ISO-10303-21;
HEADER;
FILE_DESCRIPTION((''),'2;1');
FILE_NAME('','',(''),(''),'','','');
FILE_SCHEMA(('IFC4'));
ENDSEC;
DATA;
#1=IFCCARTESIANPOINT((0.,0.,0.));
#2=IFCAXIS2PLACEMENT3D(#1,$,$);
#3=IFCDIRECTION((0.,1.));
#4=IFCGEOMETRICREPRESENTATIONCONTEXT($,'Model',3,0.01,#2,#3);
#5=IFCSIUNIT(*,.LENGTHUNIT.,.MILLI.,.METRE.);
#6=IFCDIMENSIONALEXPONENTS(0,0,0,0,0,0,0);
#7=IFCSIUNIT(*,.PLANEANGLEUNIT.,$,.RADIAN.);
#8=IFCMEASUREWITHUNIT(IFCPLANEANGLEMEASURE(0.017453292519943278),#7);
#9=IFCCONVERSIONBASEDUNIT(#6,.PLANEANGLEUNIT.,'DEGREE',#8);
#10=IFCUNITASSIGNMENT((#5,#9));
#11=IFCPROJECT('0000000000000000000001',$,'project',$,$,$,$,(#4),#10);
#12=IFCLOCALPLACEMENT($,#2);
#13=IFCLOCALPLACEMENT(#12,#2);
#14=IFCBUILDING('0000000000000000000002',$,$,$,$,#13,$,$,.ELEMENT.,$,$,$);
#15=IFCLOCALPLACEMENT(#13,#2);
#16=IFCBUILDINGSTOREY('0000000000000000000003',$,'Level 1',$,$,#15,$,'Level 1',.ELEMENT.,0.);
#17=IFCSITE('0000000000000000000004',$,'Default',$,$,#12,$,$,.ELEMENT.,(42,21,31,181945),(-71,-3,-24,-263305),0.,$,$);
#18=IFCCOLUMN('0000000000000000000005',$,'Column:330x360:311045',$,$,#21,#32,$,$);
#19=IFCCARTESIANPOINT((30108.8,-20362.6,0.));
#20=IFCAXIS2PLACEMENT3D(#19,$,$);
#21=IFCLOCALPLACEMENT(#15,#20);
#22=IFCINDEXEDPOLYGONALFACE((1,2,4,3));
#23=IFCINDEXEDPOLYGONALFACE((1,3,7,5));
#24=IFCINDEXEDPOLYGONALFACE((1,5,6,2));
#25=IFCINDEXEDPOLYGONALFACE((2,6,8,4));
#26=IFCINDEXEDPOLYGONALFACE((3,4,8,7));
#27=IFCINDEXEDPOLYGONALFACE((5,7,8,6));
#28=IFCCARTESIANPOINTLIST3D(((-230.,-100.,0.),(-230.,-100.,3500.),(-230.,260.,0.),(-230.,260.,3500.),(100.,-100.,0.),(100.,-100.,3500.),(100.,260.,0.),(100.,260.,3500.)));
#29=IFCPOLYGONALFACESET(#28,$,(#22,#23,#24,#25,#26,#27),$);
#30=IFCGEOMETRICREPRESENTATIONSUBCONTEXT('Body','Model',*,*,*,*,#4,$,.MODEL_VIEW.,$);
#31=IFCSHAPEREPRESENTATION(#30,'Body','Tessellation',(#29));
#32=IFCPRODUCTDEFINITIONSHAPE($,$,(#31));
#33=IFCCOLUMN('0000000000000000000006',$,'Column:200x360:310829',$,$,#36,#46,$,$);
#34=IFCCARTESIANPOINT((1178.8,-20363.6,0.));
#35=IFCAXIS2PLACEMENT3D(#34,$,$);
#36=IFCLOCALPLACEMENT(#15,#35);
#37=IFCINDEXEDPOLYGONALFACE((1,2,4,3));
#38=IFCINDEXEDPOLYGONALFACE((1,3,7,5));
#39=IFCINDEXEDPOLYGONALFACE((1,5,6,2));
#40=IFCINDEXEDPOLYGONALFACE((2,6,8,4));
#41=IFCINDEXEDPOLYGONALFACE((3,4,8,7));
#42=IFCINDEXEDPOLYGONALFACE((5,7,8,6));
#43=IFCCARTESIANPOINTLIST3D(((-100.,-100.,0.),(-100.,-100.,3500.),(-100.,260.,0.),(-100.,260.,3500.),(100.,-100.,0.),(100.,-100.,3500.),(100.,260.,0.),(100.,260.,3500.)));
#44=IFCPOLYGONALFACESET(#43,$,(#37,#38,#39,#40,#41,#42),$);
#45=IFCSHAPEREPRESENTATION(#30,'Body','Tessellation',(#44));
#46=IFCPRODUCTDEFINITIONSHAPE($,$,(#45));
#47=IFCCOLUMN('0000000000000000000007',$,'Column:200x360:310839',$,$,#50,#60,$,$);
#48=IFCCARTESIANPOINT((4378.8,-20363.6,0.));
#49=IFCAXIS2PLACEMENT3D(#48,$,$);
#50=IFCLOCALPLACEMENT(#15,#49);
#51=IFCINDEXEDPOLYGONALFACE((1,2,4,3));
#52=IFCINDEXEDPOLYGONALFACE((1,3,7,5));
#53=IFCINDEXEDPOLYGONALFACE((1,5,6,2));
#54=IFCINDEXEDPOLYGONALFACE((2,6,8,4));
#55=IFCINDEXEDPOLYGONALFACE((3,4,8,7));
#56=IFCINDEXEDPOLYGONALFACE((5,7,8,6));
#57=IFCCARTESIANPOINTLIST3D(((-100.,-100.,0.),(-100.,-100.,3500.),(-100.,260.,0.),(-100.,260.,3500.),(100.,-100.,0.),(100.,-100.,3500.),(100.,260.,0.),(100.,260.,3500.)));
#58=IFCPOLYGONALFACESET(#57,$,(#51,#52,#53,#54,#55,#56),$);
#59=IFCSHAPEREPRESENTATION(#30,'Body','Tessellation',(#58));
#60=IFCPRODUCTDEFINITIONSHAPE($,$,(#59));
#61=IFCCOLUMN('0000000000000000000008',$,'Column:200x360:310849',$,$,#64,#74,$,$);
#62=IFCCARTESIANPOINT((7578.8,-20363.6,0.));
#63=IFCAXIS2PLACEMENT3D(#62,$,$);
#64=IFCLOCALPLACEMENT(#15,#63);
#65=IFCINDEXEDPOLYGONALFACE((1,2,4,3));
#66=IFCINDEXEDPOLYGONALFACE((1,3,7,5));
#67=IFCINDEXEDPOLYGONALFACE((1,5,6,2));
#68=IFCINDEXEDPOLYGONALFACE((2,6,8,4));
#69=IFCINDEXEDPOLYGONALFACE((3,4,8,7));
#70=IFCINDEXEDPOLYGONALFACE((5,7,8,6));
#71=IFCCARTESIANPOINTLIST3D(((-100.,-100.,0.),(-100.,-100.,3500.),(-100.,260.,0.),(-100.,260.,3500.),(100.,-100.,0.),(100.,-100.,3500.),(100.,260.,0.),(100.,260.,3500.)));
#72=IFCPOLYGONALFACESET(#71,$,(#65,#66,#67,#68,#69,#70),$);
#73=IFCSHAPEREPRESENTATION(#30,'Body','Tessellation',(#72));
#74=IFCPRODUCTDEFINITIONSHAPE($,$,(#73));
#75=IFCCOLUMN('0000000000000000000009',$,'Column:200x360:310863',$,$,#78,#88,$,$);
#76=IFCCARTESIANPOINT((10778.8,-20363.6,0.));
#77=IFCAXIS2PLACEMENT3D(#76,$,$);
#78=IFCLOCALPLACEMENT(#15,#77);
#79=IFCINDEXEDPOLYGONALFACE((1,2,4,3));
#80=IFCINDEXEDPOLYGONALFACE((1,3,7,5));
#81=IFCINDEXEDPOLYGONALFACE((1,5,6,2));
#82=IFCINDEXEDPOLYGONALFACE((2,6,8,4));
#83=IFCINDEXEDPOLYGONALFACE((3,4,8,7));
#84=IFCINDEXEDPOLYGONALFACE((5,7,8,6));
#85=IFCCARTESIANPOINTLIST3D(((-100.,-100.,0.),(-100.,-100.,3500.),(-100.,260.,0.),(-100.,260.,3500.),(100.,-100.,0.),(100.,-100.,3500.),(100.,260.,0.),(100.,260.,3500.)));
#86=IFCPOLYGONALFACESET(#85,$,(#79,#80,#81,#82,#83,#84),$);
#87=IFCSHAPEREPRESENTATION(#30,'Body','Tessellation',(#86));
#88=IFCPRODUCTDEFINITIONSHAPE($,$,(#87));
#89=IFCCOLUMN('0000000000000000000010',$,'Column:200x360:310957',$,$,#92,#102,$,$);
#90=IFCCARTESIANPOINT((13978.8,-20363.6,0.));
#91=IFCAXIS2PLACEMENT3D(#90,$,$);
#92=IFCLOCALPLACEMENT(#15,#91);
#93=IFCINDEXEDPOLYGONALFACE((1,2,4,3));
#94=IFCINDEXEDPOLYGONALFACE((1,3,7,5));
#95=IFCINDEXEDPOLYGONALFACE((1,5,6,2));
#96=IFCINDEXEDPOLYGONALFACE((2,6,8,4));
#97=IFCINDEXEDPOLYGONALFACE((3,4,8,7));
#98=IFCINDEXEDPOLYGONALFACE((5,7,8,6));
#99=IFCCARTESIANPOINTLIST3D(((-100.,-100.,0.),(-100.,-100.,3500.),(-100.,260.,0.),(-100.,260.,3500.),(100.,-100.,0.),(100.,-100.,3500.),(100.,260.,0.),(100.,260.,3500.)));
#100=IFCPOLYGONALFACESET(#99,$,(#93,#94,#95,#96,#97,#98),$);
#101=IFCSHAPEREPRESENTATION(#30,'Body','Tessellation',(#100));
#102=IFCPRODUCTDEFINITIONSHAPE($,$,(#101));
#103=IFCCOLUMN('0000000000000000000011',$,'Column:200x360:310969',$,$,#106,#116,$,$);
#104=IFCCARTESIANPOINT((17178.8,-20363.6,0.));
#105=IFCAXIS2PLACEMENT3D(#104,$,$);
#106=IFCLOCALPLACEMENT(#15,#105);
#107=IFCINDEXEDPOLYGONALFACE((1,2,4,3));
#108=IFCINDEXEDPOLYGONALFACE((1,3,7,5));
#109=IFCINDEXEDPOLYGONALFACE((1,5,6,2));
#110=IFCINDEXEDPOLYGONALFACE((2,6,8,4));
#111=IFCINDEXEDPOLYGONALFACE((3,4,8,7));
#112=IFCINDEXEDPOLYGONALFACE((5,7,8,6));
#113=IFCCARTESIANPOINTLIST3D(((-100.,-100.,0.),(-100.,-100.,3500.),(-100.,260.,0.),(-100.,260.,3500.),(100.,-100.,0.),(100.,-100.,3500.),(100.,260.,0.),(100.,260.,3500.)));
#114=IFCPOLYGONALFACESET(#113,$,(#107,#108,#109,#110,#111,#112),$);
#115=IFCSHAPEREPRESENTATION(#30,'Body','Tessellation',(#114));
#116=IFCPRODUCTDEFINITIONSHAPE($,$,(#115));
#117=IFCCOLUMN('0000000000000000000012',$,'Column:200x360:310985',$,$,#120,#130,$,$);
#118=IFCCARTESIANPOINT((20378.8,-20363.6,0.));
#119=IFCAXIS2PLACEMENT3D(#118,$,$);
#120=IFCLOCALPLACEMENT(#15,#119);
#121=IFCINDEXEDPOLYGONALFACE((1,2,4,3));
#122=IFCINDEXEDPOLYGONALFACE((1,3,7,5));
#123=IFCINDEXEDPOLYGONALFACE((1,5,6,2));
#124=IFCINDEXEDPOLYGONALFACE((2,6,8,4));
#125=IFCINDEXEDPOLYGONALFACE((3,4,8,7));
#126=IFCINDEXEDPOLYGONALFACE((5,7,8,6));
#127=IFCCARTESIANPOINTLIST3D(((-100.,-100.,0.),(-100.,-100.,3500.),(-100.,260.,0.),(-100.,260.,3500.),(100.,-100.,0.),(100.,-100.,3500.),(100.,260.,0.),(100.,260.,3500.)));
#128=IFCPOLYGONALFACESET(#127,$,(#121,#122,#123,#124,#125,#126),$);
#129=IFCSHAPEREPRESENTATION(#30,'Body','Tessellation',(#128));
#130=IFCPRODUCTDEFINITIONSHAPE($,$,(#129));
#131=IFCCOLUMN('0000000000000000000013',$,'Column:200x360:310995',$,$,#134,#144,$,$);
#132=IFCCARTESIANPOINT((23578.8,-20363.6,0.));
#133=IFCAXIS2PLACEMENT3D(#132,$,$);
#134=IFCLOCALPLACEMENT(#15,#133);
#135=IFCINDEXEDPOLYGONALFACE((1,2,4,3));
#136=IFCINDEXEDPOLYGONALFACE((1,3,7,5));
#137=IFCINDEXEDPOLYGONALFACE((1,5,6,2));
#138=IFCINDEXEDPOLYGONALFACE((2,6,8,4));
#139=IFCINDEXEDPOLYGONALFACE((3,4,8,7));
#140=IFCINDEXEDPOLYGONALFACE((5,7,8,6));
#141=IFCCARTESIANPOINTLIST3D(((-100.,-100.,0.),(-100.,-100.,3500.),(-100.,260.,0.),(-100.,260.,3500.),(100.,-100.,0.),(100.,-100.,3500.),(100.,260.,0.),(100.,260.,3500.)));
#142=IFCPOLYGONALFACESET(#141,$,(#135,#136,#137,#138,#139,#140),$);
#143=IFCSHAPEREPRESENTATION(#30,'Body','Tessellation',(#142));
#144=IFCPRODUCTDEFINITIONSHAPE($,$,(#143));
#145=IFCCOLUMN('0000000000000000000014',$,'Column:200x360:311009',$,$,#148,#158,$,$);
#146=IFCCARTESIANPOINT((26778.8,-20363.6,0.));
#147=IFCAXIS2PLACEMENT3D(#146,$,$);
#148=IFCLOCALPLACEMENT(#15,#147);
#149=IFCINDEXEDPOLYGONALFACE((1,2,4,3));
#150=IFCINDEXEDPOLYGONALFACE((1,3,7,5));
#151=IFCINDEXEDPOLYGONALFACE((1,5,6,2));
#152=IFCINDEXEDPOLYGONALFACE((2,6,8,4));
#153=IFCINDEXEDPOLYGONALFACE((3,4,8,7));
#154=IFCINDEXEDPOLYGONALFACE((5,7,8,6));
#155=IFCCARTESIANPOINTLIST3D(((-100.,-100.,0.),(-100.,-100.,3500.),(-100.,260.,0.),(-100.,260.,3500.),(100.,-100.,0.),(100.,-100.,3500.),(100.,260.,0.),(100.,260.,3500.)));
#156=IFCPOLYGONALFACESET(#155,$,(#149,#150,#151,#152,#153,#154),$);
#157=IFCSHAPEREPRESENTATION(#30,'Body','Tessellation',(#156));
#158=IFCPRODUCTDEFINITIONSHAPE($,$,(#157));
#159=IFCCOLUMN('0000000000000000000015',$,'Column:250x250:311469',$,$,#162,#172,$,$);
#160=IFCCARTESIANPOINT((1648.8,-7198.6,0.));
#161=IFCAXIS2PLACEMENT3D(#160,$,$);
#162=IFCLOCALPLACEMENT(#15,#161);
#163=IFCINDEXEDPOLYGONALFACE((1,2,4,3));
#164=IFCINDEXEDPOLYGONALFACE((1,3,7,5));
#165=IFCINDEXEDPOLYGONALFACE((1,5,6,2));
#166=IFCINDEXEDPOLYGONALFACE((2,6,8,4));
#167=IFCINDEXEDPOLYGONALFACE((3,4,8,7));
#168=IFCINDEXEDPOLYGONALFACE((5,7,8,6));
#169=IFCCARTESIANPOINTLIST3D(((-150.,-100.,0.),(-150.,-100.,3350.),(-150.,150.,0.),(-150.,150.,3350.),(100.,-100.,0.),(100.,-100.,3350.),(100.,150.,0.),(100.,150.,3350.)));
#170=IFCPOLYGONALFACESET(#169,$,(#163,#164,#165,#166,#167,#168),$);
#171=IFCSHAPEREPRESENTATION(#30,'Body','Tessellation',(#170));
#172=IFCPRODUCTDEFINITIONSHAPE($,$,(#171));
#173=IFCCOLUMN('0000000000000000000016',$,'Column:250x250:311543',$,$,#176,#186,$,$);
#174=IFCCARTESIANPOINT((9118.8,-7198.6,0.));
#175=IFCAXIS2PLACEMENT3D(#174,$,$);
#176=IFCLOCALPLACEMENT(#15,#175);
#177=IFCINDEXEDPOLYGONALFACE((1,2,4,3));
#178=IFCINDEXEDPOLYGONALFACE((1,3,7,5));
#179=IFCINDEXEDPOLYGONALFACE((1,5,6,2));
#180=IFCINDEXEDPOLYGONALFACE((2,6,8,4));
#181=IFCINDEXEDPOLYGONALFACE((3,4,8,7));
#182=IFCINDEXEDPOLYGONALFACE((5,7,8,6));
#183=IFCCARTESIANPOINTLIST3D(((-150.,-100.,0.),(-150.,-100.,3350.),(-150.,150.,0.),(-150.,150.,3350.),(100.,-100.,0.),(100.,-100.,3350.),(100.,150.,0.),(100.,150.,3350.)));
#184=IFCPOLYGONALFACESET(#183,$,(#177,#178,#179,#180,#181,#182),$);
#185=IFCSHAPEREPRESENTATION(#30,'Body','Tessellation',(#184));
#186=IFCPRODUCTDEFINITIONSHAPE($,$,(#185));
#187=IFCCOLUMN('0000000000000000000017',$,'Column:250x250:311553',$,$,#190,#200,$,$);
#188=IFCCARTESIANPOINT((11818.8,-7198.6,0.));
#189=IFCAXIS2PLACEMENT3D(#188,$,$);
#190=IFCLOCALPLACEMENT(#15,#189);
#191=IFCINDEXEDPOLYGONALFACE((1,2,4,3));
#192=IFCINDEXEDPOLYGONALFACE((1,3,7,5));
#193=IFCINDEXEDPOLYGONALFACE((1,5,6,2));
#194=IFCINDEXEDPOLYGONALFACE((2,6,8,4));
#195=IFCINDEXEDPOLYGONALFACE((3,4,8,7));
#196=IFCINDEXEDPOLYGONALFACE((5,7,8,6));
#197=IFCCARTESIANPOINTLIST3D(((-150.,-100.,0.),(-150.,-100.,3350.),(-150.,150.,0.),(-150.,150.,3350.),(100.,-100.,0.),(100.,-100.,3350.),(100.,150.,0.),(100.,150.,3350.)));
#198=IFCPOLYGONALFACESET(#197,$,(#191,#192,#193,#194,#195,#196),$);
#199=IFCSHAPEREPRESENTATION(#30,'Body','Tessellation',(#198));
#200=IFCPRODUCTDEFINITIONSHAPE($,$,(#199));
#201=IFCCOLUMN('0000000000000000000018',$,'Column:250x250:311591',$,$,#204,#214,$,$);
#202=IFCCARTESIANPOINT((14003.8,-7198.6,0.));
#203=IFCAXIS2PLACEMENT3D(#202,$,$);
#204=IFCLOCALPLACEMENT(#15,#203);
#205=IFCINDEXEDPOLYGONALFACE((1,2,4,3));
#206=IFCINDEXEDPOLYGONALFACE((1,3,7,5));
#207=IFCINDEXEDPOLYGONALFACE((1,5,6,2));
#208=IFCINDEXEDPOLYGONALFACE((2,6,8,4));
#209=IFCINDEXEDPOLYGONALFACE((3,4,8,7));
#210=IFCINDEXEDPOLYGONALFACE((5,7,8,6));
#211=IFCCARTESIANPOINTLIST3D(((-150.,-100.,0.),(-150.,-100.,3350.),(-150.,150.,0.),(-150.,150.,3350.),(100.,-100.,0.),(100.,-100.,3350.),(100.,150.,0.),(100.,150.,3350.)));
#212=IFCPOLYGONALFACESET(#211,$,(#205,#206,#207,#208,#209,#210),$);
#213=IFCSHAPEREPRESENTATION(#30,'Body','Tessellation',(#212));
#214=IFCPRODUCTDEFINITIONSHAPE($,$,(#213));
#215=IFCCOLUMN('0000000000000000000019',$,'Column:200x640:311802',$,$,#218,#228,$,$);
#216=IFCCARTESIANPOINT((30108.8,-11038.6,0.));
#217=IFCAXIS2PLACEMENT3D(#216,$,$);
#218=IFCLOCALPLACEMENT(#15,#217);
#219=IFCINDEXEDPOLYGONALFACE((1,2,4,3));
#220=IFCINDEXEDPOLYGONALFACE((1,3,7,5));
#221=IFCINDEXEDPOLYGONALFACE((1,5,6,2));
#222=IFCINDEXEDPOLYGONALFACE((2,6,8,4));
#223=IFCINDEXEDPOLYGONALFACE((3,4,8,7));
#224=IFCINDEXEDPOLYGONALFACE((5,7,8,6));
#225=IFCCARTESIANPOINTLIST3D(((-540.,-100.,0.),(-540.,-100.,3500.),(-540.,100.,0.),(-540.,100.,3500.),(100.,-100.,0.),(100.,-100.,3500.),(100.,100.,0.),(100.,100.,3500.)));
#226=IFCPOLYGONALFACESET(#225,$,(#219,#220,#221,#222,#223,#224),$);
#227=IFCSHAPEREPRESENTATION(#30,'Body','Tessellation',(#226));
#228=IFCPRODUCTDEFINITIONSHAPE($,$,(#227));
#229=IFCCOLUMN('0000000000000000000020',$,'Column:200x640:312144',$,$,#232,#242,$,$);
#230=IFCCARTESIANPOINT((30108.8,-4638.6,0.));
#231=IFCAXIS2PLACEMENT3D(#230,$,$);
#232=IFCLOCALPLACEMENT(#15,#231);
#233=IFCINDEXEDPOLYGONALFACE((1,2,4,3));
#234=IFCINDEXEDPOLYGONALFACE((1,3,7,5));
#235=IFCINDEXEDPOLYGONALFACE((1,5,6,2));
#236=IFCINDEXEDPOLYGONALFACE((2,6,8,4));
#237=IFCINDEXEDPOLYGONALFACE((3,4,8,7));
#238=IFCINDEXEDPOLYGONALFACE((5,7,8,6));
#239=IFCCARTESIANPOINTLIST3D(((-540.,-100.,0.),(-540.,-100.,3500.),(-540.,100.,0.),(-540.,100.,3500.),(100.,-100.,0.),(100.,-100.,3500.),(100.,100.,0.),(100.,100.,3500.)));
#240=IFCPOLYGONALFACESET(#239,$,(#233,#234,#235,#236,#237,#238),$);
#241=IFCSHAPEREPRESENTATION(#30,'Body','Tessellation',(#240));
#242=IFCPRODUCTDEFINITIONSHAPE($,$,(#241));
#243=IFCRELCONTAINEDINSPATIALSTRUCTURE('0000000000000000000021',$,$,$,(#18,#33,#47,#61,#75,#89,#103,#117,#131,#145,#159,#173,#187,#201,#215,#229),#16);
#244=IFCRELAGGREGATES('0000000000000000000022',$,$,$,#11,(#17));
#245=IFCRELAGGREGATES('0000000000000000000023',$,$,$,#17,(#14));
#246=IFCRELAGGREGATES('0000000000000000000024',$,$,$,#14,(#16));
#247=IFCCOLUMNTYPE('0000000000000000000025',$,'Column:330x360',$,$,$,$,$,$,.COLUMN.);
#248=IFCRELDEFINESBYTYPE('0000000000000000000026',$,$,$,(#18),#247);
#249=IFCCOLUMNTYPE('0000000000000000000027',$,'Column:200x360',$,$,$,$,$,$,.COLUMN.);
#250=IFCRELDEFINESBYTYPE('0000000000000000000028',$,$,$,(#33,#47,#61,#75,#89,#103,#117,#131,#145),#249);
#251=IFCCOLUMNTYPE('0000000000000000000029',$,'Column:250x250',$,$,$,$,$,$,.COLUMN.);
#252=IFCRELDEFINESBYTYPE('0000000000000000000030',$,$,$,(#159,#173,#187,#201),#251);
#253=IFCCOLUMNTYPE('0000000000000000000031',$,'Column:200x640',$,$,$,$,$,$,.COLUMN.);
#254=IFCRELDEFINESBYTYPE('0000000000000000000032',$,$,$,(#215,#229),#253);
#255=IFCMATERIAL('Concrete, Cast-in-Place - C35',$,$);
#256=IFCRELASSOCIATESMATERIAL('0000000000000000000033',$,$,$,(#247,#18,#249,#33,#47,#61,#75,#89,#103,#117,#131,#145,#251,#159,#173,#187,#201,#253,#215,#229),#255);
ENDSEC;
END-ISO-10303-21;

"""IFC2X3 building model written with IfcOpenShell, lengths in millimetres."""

from ifc_helpers import new_model, entity, si_unit, converted_unit, direction, frame, frame_2d, origin, origin_2d_with_axis, place, context, subcontext, project, spatial, rectangle, extrude, source, transform, mapped, material, type_object, type_shapes, element, save


model = new_model("IFC2X3")

# Units and contexts
model_context = context("Model", 3, precision=0.01, world=origin(), true_north=direction((0.0, 1.0)))
body_context = subcontext(model_context, "Body", "Model", "MODEL_VIEW")
ifc_project = project(units=[si_unit("LENGTHUNIT", "METRE", prefix="MILLI"), converted_unit("PLANEANGLEUNIT", "DEGREE", entity("IfcPlaneAngleMeasure", 0.017453292519943278), si_unit("PLANEANGLEUNIT", "RADIAN"), dimensions=[0, 0, 0, 0, 0, 0, 0])], contexts=[model_context])

# Site, building, storey
site_placement = place(None, origin())
site = spatial("IfcSite", under=ifc_project, at=site_placement, Name="Default", CompositionType="ELEMENT", RefLatitude=(42, 21, 31, 181945), RefLongitude=(-71, -3, -24, -263305), RefElevation=0.0)
building_placement = place(site_placement, origin())
building = spatial("IfcBuilding", under=site, at=building_placement, CompositionType="ELEMENT")
storey_placement = place(building_placement, origin())
storey = spatial("IfcBuildingStorey", under=building, at=storey_placement, Name="Level 1", LongName="Level 1", CompositionType="ELEMENT", Elevation=0.0)

# Columns
ifc_material = material(Name="Concrete, Cast-in-Place - C35")
column_type_1 = type_object("IfcColumnType", Name="Column:330x360", PredefinedType="COLUMN", material=ifc_material)
shared_shape_1 = source(origin(), body_context, "Body", "SweptSolid", [
    extrude(rectangle(XDim=330.0, YDim=360.0, at=origin_2d_with_axis()), frame((-65.0, 80.0, 0.0), z_axis=(0.0, 0.0, 1.0), x_axis=(-1.0, 0.0, 0.0)), (0.0, 0.0, 1.0), 3500.0),
])
type_shapes(column_type_1, [shared_shape_1])
column_placement = place(storey_placement, frame((30108.8, -20362.6, 0.0)))
element("IfcColumn", 1, at=column_placement, inside=storey, type_object=column_type_1, material=ifc_material, Name="Column:330x360:311045", context=body_context, shape_type="MappedRepresentation", body=[
    mapped(shared_shape_1, transform((0.0, 0.0, 0.0), scale=1.0)),
])
column_type_2 = type_object("IfcColumnType", Name="Column:200x360", PredefinedType="COLUMN", material=ifc_material)
shared_shape_2 = source(origin(), body_context, "Body", "SweptSolid", [
    extrude(rectangle(XDim=200.0, YDim=360.0, at=frame_2d((0.0, 0.0), x_axis=(1.0, 0.0))), frame((0.0, 80.0, 0.0), z_axis=(0.0, 0.0, 1.0), x_axis=(-1.0, 0.0, 0.0)), (0.0, 0.0, 1.0), 3500.0),
])
type_shapes(column_type_2, [shared_shape_2])
for number, where, name in (
    (2, (1178.8, -20363.6, 0.0), "Column:200x360:310829"),
    (3, (4378.8, -20363.6, 0.0), "Column:200x360:310839"),
    (4, (7578.8, -20363.6, 0.0), "Column:200x360:310849"),
    (5, (10778.8, -20363.6, 0.0), "Column:200x360:310863"),
    (6, (13978.8, -20363.6, 0.0), "Column:200x360:310957"),
    (7, (17178.8, -20363.6, 0.0), "Column:200x360:310969"),
    (8, (20378.8, -20363.6, 0.0), "Column:200x360:310985"),
    (9, (23578.8, -20363.6, 0.0), "Column:200x360:310995"),
    (10, (26778.8, -20363.6, 0.0), "Column:200x360:311009"),
):
    element("IfcColumn", number, at=place(storey_placement, frame(where)), inside=storey, type_object=column_type_2, material=ifc_material, Name=name, context=body_context, shape_type="MappedRepresentation", body=[
        mapped(shared_shape_2, transform((0.0, 0.0, 0.0), scale=1.0)),
    ])
column_type_3 = type_object("IfcColumnType", Name="Column:250x250", PredefinedType="COLUMN", material=ifc_material)
shared_shape_3 = source(origin(), body_context, "Body", "SweptSolid", [
    extrude(rectangle(XDim=250.0, YDim=250.0, at=origin_2d_with_axis()), frame((-25.0, 25.0, 0.0), z_axis=(0.0, 0.0, 1.0), x_axis=(-1.0, 0.0, 0.0)), (0.0, 0.0, 1.0), 3350.0),
])
type_shapes(column_type_3, [shared_shape_3])
for number, where, name in (
    (11, (1648.8, -7198.6, 0.0), "Column:250x250:311469"),
    (12, (9118.8, -7198.6, 0.0), "Column:250x250:311543"),
    (13, (11818.8, -7198.6, 0.0), "Column:250x250:311553"),
    (14, (14003.8, -7198.6, 0.0), "Column:250x250:311591"),
):
    element("IfcColumn", number, at=place(storey_placement, frame(where)), inside=storey, type_object=column_type_3, material=ifc_material, Name=name, context=body_context, shape_type="MappedRepresentation", body=[
        mapped(shared_shape_3, transform((0.0, 0.0, 0.0), scale=1.0)),
    ])
column_type_4 = type_object("IfcColumnType", Name="Column:200x640", PredefinedType="COLUMN", material=ifc_material)
shared_shape_4 = source(origin(), body_context, "Body", "SweptSolid", [
    extrude(rectangle(XDim=640.0, YDim=200.0, at=origin_2d_with_axis()), frame((-220.0, 0.0, 0.0), z_axis=(0.0, 0.0, 1.0), x_axis=(-1.0, 0.0, 0.0)), (0.0, 0.0, 1.0), 3500.0),
])
type_shapes(column_type_4, [shared_shape_4])
for number, where, name in (
    (15, (30108.8, -11038.6, 0.0), "Column:200x640:311802"),
    (16, (30108.8, -4638.6, 0.0), "Column:200x640:312144"),
):
    element("IfcColumn", number, at=place(storey_placement, frame(where)), inside=storey, type_object=column_type_4, material=ifc_material, Name=name, context=body_context, shape_type="MappedRepresentation", body=[
        mapped(shared_shape_4, transform((0.0, 0.0, 0.0), scale=1.0)),
    ])

save(model, "model.ifc")
